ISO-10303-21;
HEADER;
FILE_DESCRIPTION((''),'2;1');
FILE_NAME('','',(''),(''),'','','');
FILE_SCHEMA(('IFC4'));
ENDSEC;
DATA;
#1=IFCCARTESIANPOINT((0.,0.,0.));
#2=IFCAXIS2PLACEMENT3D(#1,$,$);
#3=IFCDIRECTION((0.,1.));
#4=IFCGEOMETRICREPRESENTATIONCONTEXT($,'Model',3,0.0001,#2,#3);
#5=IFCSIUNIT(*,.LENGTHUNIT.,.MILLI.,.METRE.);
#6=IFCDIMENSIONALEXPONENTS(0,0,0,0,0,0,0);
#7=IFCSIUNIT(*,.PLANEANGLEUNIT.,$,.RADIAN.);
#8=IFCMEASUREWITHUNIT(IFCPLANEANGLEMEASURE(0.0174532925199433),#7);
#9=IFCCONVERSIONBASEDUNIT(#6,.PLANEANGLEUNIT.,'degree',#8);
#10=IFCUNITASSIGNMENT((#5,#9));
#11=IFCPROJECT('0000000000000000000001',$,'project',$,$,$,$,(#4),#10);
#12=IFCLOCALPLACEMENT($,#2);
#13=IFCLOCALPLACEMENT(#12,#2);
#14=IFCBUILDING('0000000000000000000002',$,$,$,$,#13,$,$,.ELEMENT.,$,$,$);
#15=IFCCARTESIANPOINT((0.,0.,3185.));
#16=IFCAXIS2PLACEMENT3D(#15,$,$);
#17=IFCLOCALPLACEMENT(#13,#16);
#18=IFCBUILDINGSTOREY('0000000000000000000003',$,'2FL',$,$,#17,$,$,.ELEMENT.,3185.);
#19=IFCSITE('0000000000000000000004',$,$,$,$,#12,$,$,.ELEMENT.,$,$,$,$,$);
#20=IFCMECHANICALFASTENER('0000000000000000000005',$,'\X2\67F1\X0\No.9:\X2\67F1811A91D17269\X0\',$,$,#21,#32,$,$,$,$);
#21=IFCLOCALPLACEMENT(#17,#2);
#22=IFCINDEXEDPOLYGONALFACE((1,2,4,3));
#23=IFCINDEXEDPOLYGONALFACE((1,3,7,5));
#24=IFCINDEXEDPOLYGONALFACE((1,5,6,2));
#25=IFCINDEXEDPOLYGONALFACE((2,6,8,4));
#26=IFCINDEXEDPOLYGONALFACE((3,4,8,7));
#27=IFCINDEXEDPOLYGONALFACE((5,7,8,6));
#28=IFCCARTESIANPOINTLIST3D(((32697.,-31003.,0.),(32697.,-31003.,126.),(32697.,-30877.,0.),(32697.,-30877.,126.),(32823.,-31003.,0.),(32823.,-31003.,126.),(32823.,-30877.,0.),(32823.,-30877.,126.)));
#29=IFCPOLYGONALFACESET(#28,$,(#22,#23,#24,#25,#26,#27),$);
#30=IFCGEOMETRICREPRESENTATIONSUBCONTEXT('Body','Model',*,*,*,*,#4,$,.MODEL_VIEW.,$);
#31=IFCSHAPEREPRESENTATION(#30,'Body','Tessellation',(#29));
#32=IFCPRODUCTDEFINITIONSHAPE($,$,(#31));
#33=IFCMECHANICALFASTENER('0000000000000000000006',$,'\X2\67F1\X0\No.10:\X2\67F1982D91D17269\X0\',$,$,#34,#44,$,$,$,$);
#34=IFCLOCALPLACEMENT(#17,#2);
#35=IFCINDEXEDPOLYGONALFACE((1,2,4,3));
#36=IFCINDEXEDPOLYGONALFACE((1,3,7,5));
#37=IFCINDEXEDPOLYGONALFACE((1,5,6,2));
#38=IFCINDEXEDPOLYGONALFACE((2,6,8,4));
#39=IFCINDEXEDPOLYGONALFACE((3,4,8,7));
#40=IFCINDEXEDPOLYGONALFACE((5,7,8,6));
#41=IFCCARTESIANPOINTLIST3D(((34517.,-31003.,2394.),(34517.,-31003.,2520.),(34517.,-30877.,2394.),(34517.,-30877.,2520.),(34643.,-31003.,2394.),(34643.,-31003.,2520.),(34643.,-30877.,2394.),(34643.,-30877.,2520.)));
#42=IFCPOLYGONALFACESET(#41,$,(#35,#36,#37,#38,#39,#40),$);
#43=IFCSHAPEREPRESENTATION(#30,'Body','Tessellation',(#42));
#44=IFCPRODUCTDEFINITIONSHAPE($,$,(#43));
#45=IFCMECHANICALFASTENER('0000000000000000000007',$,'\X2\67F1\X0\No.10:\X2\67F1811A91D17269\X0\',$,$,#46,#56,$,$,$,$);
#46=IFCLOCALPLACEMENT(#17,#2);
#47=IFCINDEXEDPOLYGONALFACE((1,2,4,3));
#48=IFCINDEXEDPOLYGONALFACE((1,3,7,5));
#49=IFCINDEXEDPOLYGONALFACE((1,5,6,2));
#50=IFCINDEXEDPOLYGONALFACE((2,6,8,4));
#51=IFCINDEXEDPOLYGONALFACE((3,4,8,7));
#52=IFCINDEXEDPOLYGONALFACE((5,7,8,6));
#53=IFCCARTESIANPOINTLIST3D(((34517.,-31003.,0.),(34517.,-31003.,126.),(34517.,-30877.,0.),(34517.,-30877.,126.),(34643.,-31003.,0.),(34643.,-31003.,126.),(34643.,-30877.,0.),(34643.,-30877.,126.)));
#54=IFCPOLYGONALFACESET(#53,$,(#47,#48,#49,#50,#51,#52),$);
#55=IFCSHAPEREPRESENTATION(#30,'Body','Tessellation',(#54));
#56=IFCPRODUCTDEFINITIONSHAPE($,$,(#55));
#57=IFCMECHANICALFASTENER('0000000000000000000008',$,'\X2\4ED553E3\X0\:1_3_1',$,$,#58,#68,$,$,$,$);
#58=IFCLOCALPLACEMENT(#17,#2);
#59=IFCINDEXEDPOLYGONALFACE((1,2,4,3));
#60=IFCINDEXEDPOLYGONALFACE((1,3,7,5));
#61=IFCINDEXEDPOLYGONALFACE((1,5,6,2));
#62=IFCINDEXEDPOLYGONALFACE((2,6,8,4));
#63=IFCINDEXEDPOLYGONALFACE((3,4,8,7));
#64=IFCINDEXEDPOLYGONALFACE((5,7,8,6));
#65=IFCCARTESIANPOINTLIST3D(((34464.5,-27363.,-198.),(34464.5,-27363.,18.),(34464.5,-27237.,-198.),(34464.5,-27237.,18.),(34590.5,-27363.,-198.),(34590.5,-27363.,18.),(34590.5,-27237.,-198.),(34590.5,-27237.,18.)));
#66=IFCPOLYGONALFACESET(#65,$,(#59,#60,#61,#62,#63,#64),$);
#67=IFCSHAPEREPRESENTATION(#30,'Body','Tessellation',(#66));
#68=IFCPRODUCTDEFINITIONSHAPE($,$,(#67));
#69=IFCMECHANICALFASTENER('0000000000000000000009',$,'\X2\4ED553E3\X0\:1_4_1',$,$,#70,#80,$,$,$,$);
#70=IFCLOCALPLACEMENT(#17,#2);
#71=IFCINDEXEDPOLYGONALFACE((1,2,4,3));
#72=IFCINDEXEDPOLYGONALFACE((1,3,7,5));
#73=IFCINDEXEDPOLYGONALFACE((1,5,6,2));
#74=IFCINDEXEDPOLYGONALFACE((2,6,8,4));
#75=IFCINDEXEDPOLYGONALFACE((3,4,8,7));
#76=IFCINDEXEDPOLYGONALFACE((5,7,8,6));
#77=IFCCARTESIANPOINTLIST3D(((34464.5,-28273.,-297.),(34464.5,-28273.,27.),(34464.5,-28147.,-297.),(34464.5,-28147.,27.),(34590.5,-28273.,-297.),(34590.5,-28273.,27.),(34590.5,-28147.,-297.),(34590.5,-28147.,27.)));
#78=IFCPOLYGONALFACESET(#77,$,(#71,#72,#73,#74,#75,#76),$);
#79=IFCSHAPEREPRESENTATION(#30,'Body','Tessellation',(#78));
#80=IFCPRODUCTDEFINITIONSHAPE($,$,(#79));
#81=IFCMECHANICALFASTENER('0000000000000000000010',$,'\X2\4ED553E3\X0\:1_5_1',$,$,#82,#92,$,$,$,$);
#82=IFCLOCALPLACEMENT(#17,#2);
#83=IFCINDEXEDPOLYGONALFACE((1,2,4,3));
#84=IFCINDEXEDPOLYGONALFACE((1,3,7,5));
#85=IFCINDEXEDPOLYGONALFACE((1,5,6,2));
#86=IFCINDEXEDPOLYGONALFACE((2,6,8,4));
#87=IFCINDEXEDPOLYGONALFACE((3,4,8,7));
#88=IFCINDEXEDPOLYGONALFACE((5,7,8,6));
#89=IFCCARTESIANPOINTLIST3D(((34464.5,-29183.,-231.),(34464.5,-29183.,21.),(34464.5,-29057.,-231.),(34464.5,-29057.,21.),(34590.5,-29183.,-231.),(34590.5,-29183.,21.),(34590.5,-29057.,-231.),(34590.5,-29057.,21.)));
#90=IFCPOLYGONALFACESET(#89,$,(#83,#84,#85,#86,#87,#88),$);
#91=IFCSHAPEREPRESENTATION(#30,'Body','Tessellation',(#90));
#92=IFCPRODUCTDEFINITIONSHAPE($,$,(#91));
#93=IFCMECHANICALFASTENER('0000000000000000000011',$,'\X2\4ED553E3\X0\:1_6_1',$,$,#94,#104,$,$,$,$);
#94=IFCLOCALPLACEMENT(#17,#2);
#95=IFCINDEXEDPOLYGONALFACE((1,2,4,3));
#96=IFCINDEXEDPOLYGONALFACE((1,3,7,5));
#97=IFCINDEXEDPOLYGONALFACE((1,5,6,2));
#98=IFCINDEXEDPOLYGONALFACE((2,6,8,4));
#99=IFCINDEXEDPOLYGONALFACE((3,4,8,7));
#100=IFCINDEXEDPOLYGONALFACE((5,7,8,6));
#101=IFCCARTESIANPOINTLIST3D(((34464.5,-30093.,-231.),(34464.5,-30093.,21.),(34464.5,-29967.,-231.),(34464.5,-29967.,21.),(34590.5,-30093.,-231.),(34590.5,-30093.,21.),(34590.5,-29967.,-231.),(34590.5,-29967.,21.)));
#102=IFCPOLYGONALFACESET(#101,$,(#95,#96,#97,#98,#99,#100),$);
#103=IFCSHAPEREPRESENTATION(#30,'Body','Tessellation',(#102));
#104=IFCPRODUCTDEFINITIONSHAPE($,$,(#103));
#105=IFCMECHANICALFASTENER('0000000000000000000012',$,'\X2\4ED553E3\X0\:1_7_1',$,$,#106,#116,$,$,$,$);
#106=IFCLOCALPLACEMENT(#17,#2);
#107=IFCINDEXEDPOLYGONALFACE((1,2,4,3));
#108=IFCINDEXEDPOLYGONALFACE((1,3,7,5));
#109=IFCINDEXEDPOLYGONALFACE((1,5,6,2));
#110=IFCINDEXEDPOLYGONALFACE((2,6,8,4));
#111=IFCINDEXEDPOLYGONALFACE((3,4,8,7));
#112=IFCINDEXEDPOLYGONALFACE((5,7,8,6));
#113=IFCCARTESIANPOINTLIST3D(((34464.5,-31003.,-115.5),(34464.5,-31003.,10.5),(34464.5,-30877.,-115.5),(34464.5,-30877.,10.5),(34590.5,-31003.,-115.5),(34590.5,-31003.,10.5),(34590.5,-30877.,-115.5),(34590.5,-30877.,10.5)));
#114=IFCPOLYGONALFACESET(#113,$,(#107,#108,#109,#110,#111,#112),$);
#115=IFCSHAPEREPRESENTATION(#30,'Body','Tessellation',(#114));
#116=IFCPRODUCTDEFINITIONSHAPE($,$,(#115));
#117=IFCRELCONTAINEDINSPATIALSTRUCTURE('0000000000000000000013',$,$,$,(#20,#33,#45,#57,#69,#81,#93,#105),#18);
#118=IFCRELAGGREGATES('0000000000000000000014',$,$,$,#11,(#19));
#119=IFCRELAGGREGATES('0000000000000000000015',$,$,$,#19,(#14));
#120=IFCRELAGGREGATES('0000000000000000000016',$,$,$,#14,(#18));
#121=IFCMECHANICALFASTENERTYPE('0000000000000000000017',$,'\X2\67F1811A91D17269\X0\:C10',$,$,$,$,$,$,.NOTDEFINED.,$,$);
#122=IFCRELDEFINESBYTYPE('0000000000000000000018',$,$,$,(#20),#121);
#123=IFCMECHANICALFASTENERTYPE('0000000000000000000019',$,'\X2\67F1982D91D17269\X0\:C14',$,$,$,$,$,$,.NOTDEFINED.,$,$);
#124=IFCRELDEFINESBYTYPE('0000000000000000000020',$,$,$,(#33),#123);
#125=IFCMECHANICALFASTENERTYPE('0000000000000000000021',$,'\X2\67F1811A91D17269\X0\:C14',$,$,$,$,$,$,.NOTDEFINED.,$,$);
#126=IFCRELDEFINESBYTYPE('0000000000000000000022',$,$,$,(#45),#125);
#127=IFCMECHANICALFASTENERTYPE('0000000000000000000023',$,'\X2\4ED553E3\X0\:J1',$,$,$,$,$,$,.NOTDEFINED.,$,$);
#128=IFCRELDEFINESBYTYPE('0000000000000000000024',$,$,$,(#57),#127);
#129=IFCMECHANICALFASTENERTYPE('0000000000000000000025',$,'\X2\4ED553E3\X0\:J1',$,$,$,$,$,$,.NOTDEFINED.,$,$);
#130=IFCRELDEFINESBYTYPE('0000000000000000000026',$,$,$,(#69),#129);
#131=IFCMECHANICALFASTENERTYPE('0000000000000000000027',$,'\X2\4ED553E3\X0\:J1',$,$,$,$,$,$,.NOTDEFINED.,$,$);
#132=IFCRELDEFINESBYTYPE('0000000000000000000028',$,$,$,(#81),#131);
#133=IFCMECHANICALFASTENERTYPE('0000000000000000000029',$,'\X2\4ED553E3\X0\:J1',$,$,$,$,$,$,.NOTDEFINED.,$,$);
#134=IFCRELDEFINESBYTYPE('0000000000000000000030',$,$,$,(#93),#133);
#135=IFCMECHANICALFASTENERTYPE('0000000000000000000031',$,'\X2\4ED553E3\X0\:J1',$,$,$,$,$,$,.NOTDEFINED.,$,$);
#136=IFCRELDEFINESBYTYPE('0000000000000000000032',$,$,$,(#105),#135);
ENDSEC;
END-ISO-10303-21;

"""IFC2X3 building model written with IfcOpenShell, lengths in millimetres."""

from ifc_helpers import new_model, entity, si_unit, converted_unit, direction, frame, origin, origin_with_axes, origin_2d, place, context, subcontext, project, spatial, rectangle, extrude, type_object, element, save


model = new_model("IFC2X3")

# Units and contexts
model_context = context("Model", 3, precision=0.0001, world=origin(), true_north=direction((0.0, 1.0)))
body_context = subcontext(model_context, "Body", "Model", "MODEL_VIEW")
ifc_project = project(units=[si_unit("LENGTHUNIT", "METRE", prefix="MILLI"), converted_unit("PLANEANGLEUNIT", "degree", entity("IfcPlaneAngleMeasure", 0.0174532925199433), si_unit("PLANEANGLEUNIT", "RADIAN"), dimensions=[0, 0, 0, 0, 0, 0, 0])], contexts=[model_context])

# Site, building, storey
site_placement = place(None, origin())
site = spatial("IfcSite", under=ifc_project, at=site_placement, CompositionType="ELEMENT")
building_placement = place(site_placement, origin())
building = spatial("IfcBuilding", under=site, at=building_placement, CompositionType="ELEMENT")
storey_placement = place(building_placement, frame((0.0, 0.0, 3185.0)))
storey = spatial("IfcBuildingStorey", under=building, at=storey_placement, Name="2FL", CompositionType="ELEMENT", Elevation=3185.0)

# Mechanical fasteners
mechanical_fastener_type_1 = type_object("IfcMechanicalFastenerType", Name="柱脚金物:C10")
mechanical_fastener_1_placement = place(storey_placement, frame((32760.0, -30940.0, 0.0)))
element("IfcMechanicalFastener", 1, at=mechanical_fastener_1_placement, inside=storey, type_object=mechanical_fastener_type_1, Name="柱No.9:柱脚金物", context=body_context, shape_type="SweptSolid", body=[
    extrude(rectangle(XDim=126.0, YDim=126.0, at=origin_2d()), origin_with_axes(), (0.0, 0.0, 1.0), 126.0),
])
mechanical_fastener_type_2 = type_object("IfcMechanicalFastenerType", Name="柱頭金物:C14")
mechanical_fastener_2_placement = place(storey_placement, frame((34580.0, -30940.0, 2394.0)))
element("IfcMechanicalFastener", 2, at=mechanical_fastener_2_placement, inside=storey, type_object=mechanical_fastener_type_2, Name="柱No.10:柱頭金物", context=body_context, shape_type="SweptSolid", body=[
    extrude(rectangle(XDim=126.0, YDim=126.0, at=origin_2d()), origin_with_axes(), (0.0, 0.0, 1.0), 126.0),
])
mechanical_fastener_type_3 = type_object("IfcMechanicalFastenerType", Name="柱脚金物:C14")
mechanical_fastener_3_placement = place(storey_placement, frame((34580.0, -30940.0, 0.0)))
element("IfcMechanicalFastener", 3, at=mechanical_fastener_3_placement, inside=storey, type_object=mechanical_fastener_type_3, Name="柱No.10:柱脚金物", context=body_context, shape_type="SweptSolid", body=[
    extrude(rectangle(XDim=126.0, YDim=126.0, at=origin_2d()), origin_with_axes(), (0.0, 0.0, 1.0), 126.0),
])
mechanical_fastener_type_4 = type_object("IfcMechanicalFastenerType", Name="仕口:J1")
mechanical_fastener_4_placement = place(storey_placement, frame((34527.5, -27300.0, -198.0)))
element("IfcMechanicalFastener", 4, at=mechanical_fastener_4_placement, inside=storey, type_object=mechanical_fastener_type_4, Name="仕口:1_3_1", context=body_context, shape_type="SweptSolid", body=[
    extrude(rectangle(XDim=126.0, YDim=126.0, at=origin_2d()), origin_with_axes(), (0.0, 0.0, 1.0), 216.0),
])
mechanical_fastener_type_5 = type_object("IfcMechanicalFastenerType", Name="仕口:J1")
mechanical_fastener_5_placement = place(storey_placement, frame((34527.5, -28210.0, -297.0)))
element("IfcMechanicalFastener", 5, at=mechanical_fastener_5_placement, inside=storey, type_object=mechanical_fastener_type_5, Name="仕口:1_4_1", context=body_context, shape_type="SweptSolid", body=[
    extrude(rectangle(XDim=126.0, YDim=126.0, at=origin_2d()), origin_with_axes(), (0.0, 0.0, 1.0), 324.0),
])
mechanical_fastener_type_6 = type_object("IfcMechanicalFastenerType", Name="仕口:J1")
mechanical_fastener_6_placement = place(storey_placement, frame((34527.5, -29120.0, -231.0)))
element("IfcMechanicalFastener", 6, at=mechanical_fastener_6_placement, inside=storey, type_object=mechanical_fastener_type_6, Name="仕口:1_5_1", context=body_context, shape_type="SweptSolid", body=[
    extrude(rectangle(XDim=126.0, YDim=126.0, at=origin_2d()), origin_with_axes(), (0.0, 0.0, 1.0), 252.0),
])
mechanical_fastener_type_7 = type_object("IfcMechanicalFastenerType", Name="仕口:J1")
mechanical_fastener_7_placement = place(storey_placement, frame((34527.5, -30030.0, -231.0)))
element("IfcMechanicalFastener", 7, at=mechanical_fastener_7_placement, inside=storey, type_object=mechanical_fastener_type_7, Name="仕口:1_6_1", context=body_context, shape_type="SweptSolid", body=[
    extrude(rectangle(XDim=126.0, YDim=126.0, at=origin_2d()), origin_with_axes(), (0.0, 0.0, 1.0), 252.0),
])
mechanical_fastener_type_8 = type_object("IfcMechanicalFastenerType", Name="仕口:J1")
mechanical_fastener_8_placement = place(storey_placement, frame((34527.5, -30940.0, -115.5)))
element("IfcMechanicalFastener", 8, at=mechanical_fastener_8_placement, inside=storey, type_object=mechanical_fastener_type_8, Name="仕口:1_7_1", context=body_context, shape_type="SweptSolid", body=[
    extrude(rectangle(XDim=126.0, YDim=126.0, at=origin_2d()), origin_with_axes(), (0.0, 0.0, 1.0), 126.0),
])

save(model, "model.ifc")
